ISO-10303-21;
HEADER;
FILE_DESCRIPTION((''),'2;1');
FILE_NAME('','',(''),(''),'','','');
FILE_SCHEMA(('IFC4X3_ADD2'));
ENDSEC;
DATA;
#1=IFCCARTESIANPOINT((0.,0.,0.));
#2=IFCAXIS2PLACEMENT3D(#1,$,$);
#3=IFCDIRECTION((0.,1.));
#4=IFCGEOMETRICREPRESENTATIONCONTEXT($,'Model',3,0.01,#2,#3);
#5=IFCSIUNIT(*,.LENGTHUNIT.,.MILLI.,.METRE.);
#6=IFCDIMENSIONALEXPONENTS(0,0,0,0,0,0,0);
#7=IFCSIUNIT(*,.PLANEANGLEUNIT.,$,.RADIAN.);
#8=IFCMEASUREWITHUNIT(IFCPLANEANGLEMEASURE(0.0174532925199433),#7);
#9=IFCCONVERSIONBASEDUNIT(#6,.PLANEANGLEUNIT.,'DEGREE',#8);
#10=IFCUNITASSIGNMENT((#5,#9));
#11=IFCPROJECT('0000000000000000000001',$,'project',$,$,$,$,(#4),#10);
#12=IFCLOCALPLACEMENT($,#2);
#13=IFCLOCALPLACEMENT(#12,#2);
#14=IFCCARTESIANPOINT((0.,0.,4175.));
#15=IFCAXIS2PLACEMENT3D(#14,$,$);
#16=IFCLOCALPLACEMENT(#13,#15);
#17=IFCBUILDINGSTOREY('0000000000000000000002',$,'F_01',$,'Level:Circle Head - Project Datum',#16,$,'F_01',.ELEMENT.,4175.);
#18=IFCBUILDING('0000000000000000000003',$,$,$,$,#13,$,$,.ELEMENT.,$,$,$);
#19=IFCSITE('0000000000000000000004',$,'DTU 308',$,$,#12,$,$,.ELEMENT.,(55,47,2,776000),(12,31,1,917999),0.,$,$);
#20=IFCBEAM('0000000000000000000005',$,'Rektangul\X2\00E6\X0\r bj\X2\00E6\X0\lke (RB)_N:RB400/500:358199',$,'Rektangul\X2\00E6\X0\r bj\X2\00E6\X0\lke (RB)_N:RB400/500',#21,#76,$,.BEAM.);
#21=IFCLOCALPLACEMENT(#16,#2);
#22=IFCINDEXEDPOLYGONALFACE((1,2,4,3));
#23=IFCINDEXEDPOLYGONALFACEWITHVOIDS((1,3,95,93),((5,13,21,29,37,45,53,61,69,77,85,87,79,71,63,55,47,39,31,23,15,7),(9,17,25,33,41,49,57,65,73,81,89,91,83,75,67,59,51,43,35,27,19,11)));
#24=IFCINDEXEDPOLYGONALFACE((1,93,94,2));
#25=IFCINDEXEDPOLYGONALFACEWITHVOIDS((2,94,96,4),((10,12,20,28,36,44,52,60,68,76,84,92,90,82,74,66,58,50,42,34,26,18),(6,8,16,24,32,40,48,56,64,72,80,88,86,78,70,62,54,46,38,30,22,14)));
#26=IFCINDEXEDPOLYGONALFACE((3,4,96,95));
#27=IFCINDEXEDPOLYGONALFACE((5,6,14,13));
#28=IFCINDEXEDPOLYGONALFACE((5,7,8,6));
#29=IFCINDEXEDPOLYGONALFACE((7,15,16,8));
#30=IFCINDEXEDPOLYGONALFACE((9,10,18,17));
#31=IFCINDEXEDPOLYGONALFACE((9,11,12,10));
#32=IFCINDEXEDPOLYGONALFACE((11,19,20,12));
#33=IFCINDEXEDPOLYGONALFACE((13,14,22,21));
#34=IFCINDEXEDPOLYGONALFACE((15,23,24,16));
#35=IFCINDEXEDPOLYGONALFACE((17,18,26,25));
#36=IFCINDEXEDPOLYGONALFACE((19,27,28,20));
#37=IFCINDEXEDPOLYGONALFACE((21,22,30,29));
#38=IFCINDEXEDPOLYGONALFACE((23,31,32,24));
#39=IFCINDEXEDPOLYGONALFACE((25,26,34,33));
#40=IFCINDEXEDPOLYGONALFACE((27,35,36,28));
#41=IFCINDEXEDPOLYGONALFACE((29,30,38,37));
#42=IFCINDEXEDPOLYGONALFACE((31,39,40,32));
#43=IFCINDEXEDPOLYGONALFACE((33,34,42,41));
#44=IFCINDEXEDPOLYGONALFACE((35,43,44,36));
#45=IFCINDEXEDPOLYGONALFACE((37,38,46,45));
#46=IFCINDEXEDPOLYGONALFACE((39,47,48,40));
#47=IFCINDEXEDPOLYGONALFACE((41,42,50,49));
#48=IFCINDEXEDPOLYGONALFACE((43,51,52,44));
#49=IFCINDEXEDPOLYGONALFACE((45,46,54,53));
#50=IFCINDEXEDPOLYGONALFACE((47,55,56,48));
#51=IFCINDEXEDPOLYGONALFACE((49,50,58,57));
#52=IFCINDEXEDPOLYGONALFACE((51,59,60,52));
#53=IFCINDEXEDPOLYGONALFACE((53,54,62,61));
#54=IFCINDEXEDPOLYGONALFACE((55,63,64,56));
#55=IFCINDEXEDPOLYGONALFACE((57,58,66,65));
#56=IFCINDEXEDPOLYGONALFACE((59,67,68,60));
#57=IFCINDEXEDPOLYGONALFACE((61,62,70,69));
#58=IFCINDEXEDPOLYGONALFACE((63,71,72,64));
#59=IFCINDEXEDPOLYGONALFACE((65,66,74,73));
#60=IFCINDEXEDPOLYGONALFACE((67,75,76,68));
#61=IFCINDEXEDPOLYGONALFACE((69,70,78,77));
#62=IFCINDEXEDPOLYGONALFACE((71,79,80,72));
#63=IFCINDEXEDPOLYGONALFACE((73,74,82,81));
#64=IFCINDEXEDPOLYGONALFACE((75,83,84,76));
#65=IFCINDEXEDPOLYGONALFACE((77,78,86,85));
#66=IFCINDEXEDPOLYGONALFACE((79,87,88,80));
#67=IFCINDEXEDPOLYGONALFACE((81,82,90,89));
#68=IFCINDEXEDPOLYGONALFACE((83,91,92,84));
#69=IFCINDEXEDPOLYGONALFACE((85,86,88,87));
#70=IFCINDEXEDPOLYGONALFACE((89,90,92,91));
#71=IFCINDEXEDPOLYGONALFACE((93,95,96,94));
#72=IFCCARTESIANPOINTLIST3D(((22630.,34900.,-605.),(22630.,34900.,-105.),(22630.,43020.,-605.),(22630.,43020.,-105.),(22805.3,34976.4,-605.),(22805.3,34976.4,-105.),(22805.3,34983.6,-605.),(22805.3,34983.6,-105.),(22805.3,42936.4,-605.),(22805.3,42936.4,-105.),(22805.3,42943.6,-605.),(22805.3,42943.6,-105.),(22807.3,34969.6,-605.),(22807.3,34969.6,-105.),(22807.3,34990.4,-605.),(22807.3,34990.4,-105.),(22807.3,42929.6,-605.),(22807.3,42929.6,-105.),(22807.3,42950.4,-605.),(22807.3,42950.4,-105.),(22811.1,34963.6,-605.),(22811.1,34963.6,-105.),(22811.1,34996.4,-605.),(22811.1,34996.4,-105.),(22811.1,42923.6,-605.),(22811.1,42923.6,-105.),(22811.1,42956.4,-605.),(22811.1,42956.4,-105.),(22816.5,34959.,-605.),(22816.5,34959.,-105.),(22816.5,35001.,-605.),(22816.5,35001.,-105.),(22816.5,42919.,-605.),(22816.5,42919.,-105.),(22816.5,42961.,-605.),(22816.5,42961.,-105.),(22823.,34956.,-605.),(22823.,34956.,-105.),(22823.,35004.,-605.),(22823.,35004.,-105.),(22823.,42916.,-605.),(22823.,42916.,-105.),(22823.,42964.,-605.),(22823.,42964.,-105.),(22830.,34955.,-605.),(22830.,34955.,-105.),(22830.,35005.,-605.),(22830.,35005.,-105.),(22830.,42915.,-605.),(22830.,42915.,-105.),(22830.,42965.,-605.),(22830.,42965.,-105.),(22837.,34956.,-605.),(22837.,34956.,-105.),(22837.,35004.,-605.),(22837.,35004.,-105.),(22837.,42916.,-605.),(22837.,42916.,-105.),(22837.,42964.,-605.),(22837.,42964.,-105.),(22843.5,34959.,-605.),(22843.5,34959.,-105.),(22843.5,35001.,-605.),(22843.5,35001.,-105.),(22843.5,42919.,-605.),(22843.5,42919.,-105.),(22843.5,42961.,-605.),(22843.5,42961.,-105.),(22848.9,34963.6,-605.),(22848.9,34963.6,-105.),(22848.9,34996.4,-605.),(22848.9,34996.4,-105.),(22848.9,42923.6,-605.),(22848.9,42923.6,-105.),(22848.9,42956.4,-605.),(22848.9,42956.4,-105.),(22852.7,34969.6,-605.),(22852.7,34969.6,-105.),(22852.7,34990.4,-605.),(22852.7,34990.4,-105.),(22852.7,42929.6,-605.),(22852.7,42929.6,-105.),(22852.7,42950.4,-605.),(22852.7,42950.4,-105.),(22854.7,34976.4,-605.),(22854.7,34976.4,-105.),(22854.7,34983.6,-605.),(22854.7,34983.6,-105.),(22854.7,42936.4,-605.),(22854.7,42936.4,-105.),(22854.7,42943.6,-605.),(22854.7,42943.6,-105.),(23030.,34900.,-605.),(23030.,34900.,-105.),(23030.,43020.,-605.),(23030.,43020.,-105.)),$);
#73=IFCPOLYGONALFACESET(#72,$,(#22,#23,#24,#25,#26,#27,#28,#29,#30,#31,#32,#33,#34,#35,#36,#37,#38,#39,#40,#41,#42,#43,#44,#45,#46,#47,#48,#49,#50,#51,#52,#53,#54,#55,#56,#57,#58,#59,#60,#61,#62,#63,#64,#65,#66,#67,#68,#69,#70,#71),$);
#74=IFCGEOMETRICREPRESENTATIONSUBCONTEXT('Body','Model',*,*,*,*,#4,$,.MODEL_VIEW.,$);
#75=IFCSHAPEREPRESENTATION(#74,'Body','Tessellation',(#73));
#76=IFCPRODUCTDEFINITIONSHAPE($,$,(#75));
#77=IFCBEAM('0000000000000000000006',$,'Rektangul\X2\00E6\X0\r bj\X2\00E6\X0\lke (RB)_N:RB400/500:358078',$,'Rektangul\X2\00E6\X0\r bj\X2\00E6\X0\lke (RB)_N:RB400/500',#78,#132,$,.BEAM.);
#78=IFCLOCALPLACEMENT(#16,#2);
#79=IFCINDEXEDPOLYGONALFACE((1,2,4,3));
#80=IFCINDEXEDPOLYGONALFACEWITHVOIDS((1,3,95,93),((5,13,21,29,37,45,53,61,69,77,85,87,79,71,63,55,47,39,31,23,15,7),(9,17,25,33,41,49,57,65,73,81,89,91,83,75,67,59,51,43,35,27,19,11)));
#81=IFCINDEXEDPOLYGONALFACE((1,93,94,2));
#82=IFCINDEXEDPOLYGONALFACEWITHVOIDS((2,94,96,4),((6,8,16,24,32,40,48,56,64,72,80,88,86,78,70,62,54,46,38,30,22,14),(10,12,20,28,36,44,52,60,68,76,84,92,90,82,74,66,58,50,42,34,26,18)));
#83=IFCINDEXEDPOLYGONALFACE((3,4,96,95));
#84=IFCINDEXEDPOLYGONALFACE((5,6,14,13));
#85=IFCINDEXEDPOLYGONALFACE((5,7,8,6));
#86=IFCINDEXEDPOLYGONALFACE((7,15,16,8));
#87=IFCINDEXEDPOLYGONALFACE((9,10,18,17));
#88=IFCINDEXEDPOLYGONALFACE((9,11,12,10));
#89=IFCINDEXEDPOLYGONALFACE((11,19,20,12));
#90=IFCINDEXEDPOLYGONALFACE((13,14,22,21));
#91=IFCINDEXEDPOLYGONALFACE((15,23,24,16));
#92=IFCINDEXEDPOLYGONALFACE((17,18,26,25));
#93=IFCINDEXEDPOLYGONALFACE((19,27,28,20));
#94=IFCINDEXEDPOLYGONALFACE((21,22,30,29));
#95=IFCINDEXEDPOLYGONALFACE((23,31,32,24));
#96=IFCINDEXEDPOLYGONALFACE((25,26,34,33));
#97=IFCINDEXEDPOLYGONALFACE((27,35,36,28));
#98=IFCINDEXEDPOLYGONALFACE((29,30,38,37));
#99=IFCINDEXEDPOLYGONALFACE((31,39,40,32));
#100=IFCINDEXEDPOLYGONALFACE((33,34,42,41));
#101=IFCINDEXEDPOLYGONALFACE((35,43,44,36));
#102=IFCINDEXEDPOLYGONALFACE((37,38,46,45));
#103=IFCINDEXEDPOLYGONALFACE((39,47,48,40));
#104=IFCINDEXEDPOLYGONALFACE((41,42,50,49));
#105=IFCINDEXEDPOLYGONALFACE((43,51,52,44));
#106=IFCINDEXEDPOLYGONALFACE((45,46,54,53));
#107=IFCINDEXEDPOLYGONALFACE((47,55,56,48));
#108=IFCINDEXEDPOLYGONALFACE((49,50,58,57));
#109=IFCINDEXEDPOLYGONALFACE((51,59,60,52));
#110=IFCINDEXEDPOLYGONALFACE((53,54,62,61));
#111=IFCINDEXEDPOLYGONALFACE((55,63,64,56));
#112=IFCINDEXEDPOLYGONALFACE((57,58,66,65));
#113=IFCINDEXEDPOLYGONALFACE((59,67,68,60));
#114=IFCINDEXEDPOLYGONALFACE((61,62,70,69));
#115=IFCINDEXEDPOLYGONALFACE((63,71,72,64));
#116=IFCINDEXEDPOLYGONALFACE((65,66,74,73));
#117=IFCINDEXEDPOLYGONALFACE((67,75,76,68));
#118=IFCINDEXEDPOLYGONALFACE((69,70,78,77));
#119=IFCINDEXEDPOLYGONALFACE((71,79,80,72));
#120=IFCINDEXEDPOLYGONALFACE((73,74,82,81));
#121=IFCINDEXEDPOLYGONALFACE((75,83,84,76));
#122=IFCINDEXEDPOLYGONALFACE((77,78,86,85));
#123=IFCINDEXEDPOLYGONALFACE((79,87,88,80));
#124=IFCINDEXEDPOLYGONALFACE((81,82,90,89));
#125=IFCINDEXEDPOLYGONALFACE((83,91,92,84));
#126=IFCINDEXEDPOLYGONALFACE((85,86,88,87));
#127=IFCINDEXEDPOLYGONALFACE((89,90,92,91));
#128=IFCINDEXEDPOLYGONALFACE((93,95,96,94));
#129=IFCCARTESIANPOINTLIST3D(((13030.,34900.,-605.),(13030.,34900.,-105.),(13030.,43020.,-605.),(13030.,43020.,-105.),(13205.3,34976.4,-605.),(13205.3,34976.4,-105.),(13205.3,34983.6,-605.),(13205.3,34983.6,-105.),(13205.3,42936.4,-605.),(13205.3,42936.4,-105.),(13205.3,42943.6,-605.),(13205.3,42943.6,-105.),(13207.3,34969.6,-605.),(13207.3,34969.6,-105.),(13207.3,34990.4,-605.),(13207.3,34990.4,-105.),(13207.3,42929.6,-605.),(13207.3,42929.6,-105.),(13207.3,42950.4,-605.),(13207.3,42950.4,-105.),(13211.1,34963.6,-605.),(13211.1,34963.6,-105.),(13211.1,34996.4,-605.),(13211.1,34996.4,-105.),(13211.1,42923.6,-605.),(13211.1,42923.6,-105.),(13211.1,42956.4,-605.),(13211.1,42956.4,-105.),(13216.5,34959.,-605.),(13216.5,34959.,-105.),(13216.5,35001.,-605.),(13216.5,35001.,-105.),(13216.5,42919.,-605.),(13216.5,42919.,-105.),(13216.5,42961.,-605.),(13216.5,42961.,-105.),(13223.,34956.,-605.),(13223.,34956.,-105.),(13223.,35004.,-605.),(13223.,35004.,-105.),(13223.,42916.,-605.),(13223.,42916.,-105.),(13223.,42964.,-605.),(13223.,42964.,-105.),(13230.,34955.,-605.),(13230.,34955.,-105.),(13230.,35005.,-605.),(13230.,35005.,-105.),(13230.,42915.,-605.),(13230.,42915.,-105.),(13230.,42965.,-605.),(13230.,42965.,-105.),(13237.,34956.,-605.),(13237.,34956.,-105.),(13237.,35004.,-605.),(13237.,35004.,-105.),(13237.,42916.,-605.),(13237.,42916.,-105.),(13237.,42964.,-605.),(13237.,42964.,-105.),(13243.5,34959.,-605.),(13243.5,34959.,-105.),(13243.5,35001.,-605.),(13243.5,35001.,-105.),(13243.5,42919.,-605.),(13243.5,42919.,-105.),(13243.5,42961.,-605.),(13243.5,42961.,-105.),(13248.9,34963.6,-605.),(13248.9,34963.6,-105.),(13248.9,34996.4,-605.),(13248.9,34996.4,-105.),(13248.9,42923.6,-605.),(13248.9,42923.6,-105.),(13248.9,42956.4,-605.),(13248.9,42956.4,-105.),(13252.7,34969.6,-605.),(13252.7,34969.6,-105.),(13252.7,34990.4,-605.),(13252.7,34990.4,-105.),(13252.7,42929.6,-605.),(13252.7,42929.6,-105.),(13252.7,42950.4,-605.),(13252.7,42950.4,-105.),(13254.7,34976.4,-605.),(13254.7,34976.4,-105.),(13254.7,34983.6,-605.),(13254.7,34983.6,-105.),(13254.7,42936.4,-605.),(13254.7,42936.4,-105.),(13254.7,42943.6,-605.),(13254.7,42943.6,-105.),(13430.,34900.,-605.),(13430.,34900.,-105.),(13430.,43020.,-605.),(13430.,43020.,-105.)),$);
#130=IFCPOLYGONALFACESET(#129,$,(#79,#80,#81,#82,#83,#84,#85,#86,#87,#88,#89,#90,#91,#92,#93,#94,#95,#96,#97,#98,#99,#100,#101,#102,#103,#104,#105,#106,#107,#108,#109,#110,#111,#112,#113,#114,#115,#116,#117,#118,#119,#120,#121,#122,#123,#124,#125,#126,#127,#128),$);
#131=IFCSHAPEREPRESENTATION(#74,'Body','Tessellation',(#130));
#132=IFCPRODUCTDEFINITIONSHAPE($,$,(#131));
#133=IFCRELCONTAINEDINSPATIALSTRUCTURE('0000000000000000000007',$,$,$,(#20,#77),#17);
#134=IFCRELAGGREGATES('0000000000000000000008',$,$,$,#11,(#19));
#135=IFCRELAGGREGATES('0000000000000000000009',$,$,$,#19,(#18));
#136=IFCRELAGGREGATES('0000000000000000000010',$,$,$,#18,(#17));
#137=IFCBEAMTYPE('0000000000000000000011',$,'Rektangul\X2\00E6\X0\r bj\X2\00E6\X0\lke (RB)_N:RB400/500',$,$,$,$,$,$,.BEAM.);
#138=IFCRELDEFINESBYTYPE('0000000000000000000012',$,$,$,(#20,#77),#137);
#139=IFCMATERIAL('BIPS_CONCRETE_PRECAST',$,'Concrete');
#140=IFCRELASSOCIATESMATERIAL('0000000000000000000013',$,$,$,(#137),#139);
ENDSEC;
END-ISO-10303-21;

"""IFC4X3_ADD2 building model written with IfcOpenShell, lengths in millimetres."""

from ifc_helpers import new_model, entity, si_unit, converted_unit, direction, frame, frame_2d, origin, place, context, subcontext, project, spatial, polyline, circle_curve, parameter, trimmed, segment, composite_curve, outline, extrude, source, transform, mapped, material, material_profile, profile_set, type_object, element, save


model = new_model("IFC4X3_ADD2")

# Units and contexts
model_context = context("Model", 3, precision=0.01, world=origin(), true_north=direction((0.0, 1.0)))
body_context = subcontext(model_context, "Body", "Model", "MODEL_VIEW")
ifc_project = project(units=[si_unit("LENGTHUNIT", "METRE", prefix="MILLI"), converted_unit("PLANEANGLEUNIT", "DEGREE", entity("IfcPlaneAngleMeasure", 0.0174532925199433), si_unit("PLANEANGLEUNIT", "RADIAN"), dimensions=[0, 0, 0, 0, 0, 0, 0])], contexts=[model_context])

# Site, building, storey
site_placement = place(None, origin())
site = spatial("IfcSite", under=ifc_project, at=site_placement, Name="DTU 308", CompositionType="ELEMENT", RefLatitude=(55, 47, 2, 776000), RefLongitude=(12, 31, 1, 917999), RefElevation=0.0)
building_placement = place(site_placement, origin())
building = spatial("IfcBuilding", under=site, at=building_placement, CompositionType="ELEMENT")
storey_placement = place(building_placement, frame((0.0, 0.0, 4175.0)))
storey = spatial("IfcBuildingStorey", under=building, at=storey_placement, Name="F_01", ObjectType="Level:Circle Head - Project Datum", LongName="F_01", CompositionType="ELEMENT", Elevation=4175.0)

# Beams
ifc_material_1 = material(Name="BIPS_CONCRETE_PRECAST", Category="Concrete")
ifc_material_profile_1 = material_profile(ifc_material_1, outline(polyline([(-4060.0, -200.0), (4060.0, -200.0), (4060.0, 200.0), (-4060.0, 200.0), (-4060.0, -200.0)]), holes=[composite_curve([segment(trimmed(circle_curve(frame_2d((3980.0, 0.0), x_axis=(-1.0, 0.0)), 25.0), [parameter(0.0)], [parameter(180.0)], True, "PARAMETER"), False, "CONTINUOUS"), segment(trimmed(circle_curve(frame_2d((3980.0, 0.0), x_axis=(-1.0, 0.0)), 25.0), [parameter(180.0)], [parameter(360.0)], True, "PARAMETER"), False, "CONTINUOUS")], self_intersect=False), composite_curve([segment(trimmed(circle_curve(frame_2d((-3980.0, 0.0), x_axis=(-1.0, 0.0)), 25.0), [parameter(0.0)], [parameter(180.0)], True, "PARAMETER"), False, "CONTINUOUS"), segment(trimmed(circle_curve(frame_2d((-3980.0, 0.0), x_axis=(-1.0, 0.0)), 25.0), [parameter(180.0)], [parameter(360.0)], True, "PARAMETER"), False, "CONTINUOUS")], self_intersect=False)]), Name="RB400/500")
ifc_profile_set_1 = profile_set([ifc_material_profile_1], Name="RB400/500")
beam_type_1 = type_object("IfcBeamType", Name="Rektangulær bjælke (RB)_N:RB400/500", PredefinedType="BEAM", material=ifc_profile_set_1)
shared_shape_1 = source(origin(), body_context, "Body", "SweptSolid", [
    extrude(outline(polyline([(-4060.0, -200.0), (4060.0, -200.0), (4060.0, 200.0), (-4060.0, 200.0), (-4060.0, -200.0)]), holes=[composite_curve([segment(trimmed(circle_curve(frame_2d((3980.0, 0.0), x_axis=(-1.0, 0.0)), 25.0), [parameter(0.0)], [parameter(180.0)], True, "PARAMETER"), False, "CONTINUOUS"), segment(trimmed(circle_curve(frame_2d((3980.0, 0.0), x_axis=(-1.0, 0.0)), 25.0), [parameter(180.0)], [parameter(360.0)], True, "PARAMETER"), False, "CONTINUOUS")], self_intersect=False), composite_curve([segment(trimmed(circle_curve(frame_2d((-3980.0, 0.0), x_axis=(-1.0, 0.0)), 25.0), [parameter(0.0)], [parameter(180.0)], True, "PARAMETER"), False, "CONTINUOUS"), segment(trimmed(circle_curve(frame_2d((-3980.0, 0.0), x_axis=(-1.0, 0.0)), 25.0), [parameter(180.0)], [parameter(360.0)], True, "PARAMETER"), False, "CONTINUOUS")], self_intersect=False)]), frame((0.0, 0.0, -250.0), z_axis=(0.0, 0.0, 1.0), x_axis=(-1.0, 0.0, 0.0)), (0.0, 0.0, 1.0), 500.0),
])
for number, where, z_axis, x_axis, name in (
    (1, (22830.0, 38960.0, -355.0), (0.0, 0.0, 1.0), (0.0, -1.0, 0.0), "Rektangulær bjælke (RB)_N:RB400/500:358199"),
):
    element("IfcBeam", number, at=place(storey_placement, frame(where, z_axis=z_axis, x_axis=x_axis)), inside=storey, type_object=beam_type_1, Name=name, ObjectType="Rektangulær bjælke (RB)_N:RB400/500", PredefinedType="BEAM", context=body_context, shape_type="MappedRepresentation", body=[
        mapped(shared_shape_1, transform((0.0, 0.0, 0.0), scale=1.0)),
    ])
shared_shape_2 = source(origin(), body_context, "Body", "SweptSolid", [
    extrude(outline(polyline([(-4060.0, -200.0), (4060.0, -200.0), (4060.0, 200.0), (-4060.0, 200.0), (-4060.0, -200.0)]), holes=[composite_curve([segment(trimmed(circle_curve(frame_2d((3980.0, 0.0), x_axis=(-1.0, 0.0)), 25.0), [parameter(0.0)], [parameter(180.0)], True, "PARAMETER"), False, "CONTINUOUS"), segment(trimmed(circle_curve(frame_2d((3980.0, 0.0), x_axis=(-1.0, 0.0)), 25.0), [parameter(180.0)], [parameter(360.0)], True, "PARAMETER"), False, "CONTINUOUS")], self_intersect=False), composite_curve([segment(trimmed(circle_curve(frame_2d((-3980.0, 0.0), x_axis=(-1.0, 0.0)), 25.0), [parameter(0.0)], [parameter(180.0)], True, "PARAMETER"), False, "CONTINUOUS"), segment(trimmed(circle_curve(frame_2d((-3980.0, 0.0), x_axis=(-1.0, 0.0)), 25.0), [parameter(180.0)], [parameter(360.0)], True, "PARAMETER"), False, "CONTINUOUS")], self_intersect=False)]), frame((10.0, 0.0, -250.0), z_axis=(0.0, 0.0, 1.0), x_axis=(-1.0, 0.0, 0.0)), (0.0, 0.0, 1.0), 500.0),
])
for number, where, z_axis, x_axis, name in (
    (2, (13230.0, 38950.0, -355.0), (0.0, 0.0, 1.0), (0.0, 1.0, 0.0), "Rektangulær bjælke (RB)_N:RB400/500:358078"),
):
    element("IfcBeam", number, at=place(storey_placement, frame(where, z_axis=z_axis, x_axis=x_axis)), inside=storey, type_object=beam_type_1, Name=name, ObjectType="Rektangulær bjælke (RB)_N:RB400/500", PredefinedType="BEAM", context=body_context, shape_type="MappedRepresentation", body=[
        mapped(shared_shape_2, transform((0.0, 0.0, 0.0), scale=1.0)),
    ])

save(model, "model.ifc")
